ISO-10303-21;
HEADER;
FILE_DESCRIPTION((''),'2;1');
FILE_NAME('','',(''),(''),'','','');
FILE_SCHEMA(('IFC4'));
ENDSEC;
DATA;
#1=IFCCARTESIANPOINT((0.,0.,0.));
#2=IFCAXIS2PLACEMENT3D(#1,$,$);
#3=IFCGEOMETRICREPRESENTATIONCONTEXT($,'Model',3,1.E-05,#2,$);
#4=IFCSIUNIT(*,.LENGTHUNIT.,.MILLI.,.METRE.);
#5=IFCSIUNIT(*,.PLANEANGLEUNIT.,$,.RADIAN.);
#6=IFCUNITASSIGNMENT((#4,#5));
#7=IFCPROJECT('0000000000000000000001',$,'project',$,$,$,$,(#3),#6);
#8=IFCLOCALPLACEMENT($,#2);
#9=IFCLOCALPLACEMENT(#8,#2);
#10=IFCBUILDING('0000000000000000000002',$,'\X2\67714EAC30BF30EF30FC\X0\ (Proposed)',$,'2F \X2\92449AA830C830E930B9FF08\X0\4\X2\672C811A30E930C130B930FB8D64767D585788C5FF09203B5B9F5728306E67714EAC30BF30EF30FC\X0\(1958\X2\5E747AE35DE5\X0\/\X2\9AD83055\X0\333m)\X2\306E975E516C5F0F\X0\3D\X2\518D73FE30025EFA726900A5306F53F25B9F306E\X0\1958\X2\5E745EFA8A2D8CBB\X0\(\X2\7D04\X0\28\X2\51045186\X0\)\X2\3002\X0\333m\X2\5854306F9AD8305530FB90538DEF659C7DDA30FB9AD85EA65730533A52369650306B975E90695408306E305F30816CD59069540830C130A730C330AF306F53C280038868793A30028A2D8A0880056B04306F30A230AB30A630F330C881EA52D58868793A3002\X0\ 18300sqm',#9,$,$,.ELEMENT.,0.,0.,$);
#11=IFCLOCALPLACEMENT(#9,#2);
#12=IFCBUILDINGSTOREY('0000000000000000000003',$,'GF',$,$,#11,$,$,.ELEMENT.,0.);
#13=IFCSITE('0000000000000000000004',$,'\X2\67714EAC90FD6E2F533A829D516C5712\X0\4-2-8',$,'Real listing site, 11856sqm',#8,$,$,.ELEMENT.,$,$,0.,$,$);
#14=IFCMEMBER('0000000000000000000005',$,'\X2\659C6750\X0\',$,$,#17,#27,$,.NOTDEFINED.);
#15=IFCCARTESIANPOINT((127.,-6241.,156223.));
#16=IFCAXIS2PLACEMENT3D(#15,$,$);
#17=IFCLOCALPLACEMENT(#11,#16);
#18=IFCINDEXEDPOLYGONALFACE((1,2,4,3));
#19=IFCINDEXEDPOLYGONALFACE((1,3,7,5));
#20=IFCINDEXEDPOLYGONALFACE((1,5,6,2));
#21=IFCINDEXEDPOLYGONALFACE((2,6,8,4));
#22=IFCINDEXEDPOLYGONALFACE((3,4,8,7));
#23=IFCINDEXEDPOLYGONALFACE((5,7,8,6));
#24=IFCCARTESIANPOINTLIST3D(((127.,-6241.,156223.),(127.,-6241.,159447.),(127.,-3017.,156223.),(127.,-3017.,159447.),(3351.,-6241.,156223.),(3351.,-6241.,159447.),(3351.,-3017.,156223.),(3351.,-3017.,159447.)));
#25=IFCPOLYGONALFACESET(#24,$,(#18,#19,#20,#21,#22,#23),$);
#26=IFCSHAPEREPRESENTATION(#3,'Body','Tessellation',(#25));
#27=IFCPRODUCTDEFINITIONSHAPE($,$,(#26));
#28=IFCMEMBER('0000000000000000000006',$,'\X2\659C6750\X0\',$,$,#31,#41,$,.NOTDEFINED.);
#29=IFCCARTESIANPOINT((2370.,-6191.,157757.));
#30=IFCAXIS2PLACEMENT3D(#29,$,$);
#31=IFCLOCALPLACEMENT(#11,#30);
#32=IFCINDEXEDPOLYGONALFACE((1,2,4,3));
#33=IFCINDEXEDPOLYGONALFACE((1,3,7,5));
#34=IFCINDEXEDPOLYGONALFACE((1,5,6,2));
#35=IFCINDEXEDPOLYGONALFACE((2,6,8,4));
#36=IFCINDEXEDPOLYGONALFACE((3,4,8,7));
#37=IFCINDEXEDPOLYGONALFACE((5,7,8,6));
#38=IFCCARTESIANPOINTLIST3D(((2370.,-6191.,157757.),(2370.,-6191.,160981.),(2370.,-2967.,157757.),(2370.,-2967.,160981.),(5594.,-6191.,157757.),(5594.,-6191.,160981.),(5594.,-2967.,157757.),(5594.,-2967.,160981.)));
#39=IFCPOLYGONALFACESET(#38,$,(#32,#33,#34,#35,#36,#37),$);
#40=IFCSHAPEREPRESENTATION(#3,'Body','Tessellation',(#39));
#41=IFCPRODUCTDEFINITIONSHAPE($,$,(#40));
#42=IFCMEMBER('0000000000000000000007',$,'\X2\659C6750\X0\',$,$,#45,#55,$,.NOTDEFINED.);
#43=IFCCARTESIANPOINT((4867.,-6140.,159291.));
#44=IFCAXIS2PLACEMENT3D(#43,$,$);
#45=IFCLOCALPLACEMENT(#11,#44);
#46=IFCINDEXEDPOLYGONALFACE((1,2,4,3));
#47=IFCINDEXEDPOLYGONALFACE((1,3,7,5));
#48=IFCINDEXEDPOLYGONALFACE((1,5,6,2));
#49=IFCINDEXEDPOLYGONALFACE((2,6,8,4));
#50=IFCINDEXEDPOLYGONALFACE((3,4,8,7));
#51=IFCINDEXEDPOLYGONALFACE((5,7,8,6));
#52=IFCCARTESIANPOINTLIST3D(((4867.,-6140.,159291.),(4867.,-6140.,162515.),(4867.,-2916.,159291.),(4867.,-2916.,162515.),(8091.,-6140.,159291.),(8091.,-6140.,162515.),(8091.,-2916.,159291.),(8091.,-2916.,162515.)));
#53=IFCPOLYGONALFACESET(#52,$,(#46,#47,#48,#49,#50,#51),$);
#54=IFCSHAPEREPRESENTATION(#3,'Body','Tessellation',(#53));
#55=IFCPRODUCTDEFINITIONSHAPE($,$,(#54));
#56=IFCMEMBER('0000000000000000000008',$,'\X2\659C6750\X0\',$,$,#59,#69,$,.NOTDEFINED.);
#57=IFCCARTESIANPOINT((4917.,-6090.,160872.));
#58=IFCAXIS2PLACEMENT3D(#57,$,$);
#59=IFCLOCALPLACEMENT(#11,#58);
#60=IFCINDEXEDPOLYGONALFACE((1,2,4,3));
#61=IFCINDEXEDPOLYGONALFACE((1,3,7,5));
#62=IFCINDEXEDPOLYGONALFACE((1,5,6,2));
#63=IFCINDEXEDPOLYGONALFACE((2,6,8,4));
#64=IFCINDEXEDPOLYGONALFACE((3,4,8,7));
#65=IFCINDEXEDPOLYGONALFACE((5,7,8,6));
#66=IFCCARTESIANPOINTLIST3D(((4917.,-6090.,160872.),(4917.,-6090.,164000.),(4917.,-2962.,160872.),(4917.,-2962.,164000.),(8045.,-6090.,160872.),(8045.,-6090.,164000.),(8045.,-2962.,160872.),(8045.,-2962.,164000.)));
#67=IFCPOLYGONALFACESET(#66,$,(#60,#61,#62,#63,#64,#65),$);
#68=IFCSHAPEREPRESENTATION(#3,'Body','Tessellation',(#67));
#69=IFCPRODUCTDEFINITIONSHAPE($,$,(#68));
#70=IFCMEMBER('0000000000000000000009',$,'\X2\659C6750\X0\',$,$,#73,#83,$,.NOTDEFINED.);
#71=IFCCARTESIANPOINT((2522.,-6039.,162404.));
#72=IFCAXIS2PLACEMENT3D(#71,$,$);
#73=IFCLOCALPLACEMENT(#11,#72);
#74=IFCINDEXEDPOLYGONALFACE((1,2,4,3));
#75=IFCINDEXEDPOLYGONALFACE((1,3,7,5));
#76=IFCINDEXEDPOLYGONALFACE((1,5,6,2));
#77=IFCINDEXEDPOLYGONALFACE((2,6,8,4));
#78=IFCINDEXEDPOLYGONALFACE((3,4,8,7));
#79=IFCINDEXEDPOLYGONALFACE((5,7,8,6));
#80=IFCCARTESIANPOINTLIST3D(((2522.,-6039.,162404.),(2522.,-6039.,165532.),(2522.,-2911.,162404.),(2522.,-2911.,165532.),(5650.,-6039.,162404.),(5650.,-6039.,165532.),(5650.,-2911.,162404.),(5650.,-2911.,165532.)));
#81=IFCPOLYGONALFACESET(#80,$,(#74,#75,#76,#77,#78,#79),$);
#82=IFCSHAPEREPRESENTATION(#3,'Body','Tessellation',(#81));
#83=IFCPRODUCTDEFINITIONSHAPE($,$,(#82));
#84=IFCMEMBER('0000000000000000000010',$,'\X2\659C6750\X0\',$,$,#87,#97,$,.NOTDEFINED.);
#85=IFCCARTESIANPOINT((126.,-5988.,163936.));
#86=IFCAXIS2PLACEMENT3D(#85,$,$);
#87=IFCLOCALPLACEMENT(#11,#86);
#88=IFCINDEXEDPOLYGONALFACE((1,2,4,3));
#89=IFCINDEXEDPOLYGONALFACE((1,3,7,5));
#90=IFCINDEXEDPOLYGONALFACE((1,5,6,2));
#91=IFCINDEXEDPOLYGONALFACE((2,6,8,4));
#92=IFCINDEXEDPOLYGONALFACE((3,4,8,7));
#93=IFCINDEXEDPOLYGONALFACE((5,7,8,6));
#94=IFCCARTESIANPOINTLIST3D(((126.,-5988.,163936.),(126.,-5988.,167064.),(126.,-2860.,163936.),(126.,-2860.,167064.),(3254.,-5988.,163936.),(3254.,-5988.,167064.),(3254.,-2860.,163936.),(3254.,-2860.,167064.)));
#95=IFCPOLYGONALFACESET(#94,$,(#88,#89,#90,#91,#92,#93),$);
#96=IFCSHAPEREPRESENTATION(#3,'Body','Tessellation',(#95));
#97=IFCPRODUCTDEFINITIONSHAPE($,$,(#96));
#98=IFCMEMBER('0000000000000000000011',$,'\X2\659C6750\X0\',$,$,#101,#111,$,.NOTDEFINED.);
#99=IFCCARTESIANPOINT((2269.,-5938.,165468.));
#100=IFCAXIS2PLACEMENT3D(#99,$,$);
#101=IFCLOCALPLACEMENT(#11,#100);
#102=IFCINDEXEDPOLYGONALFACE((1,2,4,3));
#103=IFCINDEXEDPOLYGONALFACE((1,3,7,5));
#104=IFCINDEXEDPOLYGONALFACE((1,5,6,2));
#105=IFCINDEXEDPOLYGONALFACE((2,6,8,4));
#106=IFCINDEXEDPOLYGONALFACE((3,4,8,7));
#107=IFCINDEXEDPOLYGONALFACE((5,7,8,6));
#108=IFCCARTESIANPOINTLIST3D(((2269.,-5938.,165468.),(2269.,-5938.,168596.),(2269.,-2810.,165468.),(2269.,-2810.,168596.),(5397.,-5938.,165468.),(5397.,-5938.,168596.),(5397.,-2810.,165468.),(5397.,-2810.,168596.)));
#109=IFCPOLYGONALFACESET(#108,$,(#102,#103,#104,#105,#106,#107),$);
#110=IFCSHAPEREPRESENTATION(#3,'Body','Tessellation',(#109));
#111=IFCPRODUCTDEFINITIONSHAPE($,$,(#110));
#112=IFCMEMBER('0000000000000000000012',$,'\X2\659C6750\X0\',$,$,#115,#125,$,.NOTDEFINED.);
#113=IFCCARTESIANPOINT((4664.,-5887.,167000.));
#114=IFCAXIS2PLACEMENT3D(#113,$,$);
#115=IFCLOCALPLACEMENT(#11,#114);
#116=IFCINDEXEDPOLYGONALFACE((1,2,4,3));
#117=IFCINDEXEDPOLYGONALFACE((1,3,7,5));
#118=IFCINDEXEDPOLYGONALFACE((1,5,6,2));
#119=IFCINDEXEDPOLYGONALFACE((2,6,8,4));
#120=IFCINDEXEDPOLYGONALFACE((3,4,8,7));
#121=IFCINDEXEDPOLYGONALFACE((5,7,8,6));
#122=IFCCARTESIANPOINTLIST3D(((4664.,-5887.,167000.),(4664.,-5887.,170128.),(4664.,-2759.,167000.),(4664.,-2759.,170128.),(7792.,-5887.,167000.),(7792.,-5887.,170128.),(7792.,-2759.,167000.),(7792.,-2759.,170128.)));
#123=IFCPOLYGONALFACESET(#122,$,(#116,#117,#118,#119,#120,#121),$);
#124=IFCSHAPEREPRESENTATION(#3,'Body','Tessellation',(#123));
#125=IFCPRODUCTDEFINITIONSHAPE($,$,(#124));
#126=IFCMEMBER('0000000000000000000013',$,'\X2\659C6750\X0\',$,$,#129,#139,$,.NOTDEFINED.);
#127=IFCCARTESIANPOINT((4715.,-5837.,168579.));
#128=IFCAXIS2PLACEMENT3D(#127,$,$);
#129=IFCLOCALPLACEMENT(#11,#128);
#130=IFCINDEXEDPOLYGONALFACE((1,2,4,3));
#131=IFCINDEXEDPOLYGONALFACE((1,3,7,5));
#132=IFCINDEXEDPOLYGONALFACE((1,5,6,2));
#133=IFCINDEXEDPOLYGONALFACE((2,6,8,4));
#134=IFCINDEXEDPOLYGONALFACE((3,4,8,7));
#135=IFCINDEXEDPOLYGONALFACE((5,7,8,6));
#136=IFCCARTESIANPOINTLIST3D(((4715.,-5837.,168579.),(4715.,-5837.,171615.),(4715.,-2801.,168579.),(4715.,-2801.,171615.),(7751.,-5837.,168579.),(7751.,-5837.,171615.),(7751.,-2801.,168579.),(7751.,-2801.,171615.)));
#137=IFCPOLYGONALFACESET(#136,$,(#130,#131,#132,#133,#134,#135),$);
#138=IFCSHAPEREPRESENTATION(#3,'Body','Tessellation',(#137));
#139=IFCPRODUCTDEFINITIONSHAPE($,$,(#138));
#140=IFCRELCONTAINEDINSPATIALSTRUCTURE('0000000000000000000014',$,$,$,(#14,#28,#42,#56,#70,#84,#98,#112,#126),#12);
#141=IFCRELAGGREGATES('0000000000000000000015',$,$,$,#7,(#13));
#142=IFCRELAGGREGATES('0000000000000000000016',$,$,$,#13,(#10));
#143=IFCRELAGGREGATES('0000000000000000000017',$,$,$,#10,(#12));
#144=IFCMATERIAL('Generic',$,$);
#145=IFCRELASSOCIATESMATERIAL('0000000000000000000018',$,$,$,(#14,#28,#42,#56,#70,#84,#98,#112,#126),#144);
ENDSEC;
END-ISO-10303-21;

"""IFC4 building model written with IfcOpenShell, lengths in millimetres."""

from ifc_helpers import new_model, si_unit, frame, frame_2d, origin, place, context, project, spatial, rectangle, extrude, material, element, save


model = new_model("IFC4")

# Units and contexts
model_context = context("Model", 3, precision=1e-05, world=origin())
ifc_project = project(units=[si_unit("LENGTHUNIT", "METRE", prefix="MILLI"), si_unit("PLANEANGLEUNIT", "RADIAN")], contexts=[model_context])

# Site, building, storey
site_placement = place(None, origin())
site = spatial("IfcSite", under=ifc_project, at=site_placement, Name="東京都港区芝公園4-2-8", ObjectType="Real listing site, 11856sqm", CompositionType="ELEMENT", RefElevation=0.0)
building_placement = place(site_placement, origin())
building = spatial("IfcBuilding", under=site, at=building_placement, Name="東京タワー (Proposed)", ObjectType="2F 鉄骨トラス（4本脚ラチス・赤白塗装）※実在の東京タワー(1958年竣工/高さ333m)の非公式3D再現。建物¥は史実の1958年建設費(約28億円)。333m塔は高さ・道路斜線・高度地区制限に非適合のため法適合チェックは参考表示。設計者欄はアカウント自動表示。 18300sqm", CompositionType="ELEMENT", ElevationOfRefHeight=0.0, ElevationOfTerrain=0.0)
storey_placement = place(building_placement, origin())
storey = spatial("IfcBuildingStorey", under=building, at=storey_placement, Name="GF", CompositionType="ELEMENT", Elevation=0.0)

# Shared definitions
ifc_material = material(Name="Generic")

# Members
member_1_placement = place(storey_placement, frame((127.0, -6241.0, 156223.0)))
element("IfcMember", 1, at=member_1_placement, inside=storey, material=ifc_material, Name="斜材", PredefinedType="NOTDEFINED", context=model_context, shape_type="SweptSolid", body=[
    extrude(rectangle(XDim=3224.0, YDim=3224.0, at=frame_2d((1612.0, 1612.0))), frame((127.0, -6241.0, 156223.0)), (0.0, 0.0, 1.0), 3224.0),
])
member_2_placement = place(storey_placement, frame((2370.0, -6191.0, 157757.0)))
element("IfcMember", 2, at=member_2_placement, inside=storey, material=ifc_material, Name="斜材", PredefinedType="NOTDEFINED", context=model_context, shape_type="SweptSolid", body=[
    extrude(rectangle(XDim=3224.0, YDim=3224.0, at=frame_2d((1612.0, 1612.0))), frame((2370.0, -6191.0, 157757.0)), (0.0, 0.0, 1.0), 3224.0),
])
member_3_placement = place(storey_placement, frame((4867.0, -6140.0, 159291.0)))
element("IfcMember", 3, at=member_3_placement, inside=storey, material=ifc_material, Name="斜材", PredefinedType="NOTDEFINED", context=model_context, shape_type="SweptSolid", body=[
    extrude(rectangle(XDim=3224.0, YDim=3224.0, at=frame_2d((1612.0, 1612.0))), frame((4867.0, -6140.0, 159291.0)), (0.0, 0.0, 1.0), 3224.0),
])
member_4_placement = place(storey_placement, frame((4917.0, -6090.0, 160872.0)))
element("IfcMember", 4, at=member_4_placement, inside=storey, material=ifc_material, Name="斜材", PredefinedType="NOTDEFINED", context=model_context, shape_type="SweptSolid", body=[
    extrude(rectangle(XDim=3128.0, YDim=3128.0, at=frame_2d((1564.0, 1564.0))), frame((4917.0, -6090.0, 160872.0)), (0.0, 0.0, 1.0), 3128.0),
])
member_5_placement = place(storey_placement, frame((2522.0, -6039.0, 162404.0)))
element("IfcMember", 5, at=member_5_placement, inside=storey, material=ifc_material, Name="斜材", PredefinedType="NOTDEFINED", context=model_context, shape_type="SweptSolid", body=[
    extrude(rectangle(XDim=3128.0, YDim=3128.0, at=frame_2d((1564.0, 1564.0))), frame((2522.0, -6039.0, 162404.0)), (0.0, 0.0, 1.0), 3128.0),
])
member_6_placement = place(storey_placement, frame((126.0, -5988.0, 163936.0)))
element("IfcMember", 6, at=member_6_placement, inside=storey, material=ifc_material, Name="斜材", PredefinedType="NOTDEFINED", context=model_context, shape_type="SweptSolid", body=[
    extrude(rectangle(XDim=3128.0, YDim=3128.0, at=frame_2d((1564.0, 1564.0))), frame((126.0, -5988.0, 163936.0)), (0.0, 0.0, 1.0), 3128.0),
])
member_7_placement = place(storey_placement, frame((2269.0, -5938.0, 165468.0)))
element("IfcMember", 7, at=member_7_placement, inside=storey, material=ifc_material, Name="斜材", PredefinedType="NOTDEFINED", context=model_context, shape_type="SweptSolid", body=[
    extrude(rectangle(XDim=3128.0, YDim=3128.0, at=frame_2d((1564.0, 1564.0))), frame((2269.0, -5938.0, 165468.0)), (0.0, 0.0, 1.0), 3128.0),
])
member_8_placement = place(storey_placement, frame((4664.0, -5887.0, 167000.0)))
element("IfcMember", 8, at=member_8_placement, inside=storey, material=ifc_material, Name="斜材", PredefinedType="NOTDEFINED", context=model_context, shape_type="SweptSolid", body=[
    extrude(rectangle(XDim=3128.0, YDim=3128.0, at=frame_2d((1564.0, 1564.0))), frame((4664.0, -5887.0, 167000.0)), (0.0, 0.0, 1.0), 3128.0),
])
member_9_placement = place(storey_placement, frame((4715.0, -5837.0, 168579.0)))
element("IfcMember", 9, at=member_9_placement, inside=storey, material=ifc_material, Name="斜材", PredefinedType="NOTDEFINED", context=model_context, shape_type="SweptSolid", body=[
    extrude(rectangle(XDim=3036.0, YDim=3036.0, at=frame_2d((1518.0, 1518.0))), frame((4715.0, -5837.0, 168579.0)), (0.0, 0.0, 1.0), 3036.0),
])

save(model, "model.ifc")
